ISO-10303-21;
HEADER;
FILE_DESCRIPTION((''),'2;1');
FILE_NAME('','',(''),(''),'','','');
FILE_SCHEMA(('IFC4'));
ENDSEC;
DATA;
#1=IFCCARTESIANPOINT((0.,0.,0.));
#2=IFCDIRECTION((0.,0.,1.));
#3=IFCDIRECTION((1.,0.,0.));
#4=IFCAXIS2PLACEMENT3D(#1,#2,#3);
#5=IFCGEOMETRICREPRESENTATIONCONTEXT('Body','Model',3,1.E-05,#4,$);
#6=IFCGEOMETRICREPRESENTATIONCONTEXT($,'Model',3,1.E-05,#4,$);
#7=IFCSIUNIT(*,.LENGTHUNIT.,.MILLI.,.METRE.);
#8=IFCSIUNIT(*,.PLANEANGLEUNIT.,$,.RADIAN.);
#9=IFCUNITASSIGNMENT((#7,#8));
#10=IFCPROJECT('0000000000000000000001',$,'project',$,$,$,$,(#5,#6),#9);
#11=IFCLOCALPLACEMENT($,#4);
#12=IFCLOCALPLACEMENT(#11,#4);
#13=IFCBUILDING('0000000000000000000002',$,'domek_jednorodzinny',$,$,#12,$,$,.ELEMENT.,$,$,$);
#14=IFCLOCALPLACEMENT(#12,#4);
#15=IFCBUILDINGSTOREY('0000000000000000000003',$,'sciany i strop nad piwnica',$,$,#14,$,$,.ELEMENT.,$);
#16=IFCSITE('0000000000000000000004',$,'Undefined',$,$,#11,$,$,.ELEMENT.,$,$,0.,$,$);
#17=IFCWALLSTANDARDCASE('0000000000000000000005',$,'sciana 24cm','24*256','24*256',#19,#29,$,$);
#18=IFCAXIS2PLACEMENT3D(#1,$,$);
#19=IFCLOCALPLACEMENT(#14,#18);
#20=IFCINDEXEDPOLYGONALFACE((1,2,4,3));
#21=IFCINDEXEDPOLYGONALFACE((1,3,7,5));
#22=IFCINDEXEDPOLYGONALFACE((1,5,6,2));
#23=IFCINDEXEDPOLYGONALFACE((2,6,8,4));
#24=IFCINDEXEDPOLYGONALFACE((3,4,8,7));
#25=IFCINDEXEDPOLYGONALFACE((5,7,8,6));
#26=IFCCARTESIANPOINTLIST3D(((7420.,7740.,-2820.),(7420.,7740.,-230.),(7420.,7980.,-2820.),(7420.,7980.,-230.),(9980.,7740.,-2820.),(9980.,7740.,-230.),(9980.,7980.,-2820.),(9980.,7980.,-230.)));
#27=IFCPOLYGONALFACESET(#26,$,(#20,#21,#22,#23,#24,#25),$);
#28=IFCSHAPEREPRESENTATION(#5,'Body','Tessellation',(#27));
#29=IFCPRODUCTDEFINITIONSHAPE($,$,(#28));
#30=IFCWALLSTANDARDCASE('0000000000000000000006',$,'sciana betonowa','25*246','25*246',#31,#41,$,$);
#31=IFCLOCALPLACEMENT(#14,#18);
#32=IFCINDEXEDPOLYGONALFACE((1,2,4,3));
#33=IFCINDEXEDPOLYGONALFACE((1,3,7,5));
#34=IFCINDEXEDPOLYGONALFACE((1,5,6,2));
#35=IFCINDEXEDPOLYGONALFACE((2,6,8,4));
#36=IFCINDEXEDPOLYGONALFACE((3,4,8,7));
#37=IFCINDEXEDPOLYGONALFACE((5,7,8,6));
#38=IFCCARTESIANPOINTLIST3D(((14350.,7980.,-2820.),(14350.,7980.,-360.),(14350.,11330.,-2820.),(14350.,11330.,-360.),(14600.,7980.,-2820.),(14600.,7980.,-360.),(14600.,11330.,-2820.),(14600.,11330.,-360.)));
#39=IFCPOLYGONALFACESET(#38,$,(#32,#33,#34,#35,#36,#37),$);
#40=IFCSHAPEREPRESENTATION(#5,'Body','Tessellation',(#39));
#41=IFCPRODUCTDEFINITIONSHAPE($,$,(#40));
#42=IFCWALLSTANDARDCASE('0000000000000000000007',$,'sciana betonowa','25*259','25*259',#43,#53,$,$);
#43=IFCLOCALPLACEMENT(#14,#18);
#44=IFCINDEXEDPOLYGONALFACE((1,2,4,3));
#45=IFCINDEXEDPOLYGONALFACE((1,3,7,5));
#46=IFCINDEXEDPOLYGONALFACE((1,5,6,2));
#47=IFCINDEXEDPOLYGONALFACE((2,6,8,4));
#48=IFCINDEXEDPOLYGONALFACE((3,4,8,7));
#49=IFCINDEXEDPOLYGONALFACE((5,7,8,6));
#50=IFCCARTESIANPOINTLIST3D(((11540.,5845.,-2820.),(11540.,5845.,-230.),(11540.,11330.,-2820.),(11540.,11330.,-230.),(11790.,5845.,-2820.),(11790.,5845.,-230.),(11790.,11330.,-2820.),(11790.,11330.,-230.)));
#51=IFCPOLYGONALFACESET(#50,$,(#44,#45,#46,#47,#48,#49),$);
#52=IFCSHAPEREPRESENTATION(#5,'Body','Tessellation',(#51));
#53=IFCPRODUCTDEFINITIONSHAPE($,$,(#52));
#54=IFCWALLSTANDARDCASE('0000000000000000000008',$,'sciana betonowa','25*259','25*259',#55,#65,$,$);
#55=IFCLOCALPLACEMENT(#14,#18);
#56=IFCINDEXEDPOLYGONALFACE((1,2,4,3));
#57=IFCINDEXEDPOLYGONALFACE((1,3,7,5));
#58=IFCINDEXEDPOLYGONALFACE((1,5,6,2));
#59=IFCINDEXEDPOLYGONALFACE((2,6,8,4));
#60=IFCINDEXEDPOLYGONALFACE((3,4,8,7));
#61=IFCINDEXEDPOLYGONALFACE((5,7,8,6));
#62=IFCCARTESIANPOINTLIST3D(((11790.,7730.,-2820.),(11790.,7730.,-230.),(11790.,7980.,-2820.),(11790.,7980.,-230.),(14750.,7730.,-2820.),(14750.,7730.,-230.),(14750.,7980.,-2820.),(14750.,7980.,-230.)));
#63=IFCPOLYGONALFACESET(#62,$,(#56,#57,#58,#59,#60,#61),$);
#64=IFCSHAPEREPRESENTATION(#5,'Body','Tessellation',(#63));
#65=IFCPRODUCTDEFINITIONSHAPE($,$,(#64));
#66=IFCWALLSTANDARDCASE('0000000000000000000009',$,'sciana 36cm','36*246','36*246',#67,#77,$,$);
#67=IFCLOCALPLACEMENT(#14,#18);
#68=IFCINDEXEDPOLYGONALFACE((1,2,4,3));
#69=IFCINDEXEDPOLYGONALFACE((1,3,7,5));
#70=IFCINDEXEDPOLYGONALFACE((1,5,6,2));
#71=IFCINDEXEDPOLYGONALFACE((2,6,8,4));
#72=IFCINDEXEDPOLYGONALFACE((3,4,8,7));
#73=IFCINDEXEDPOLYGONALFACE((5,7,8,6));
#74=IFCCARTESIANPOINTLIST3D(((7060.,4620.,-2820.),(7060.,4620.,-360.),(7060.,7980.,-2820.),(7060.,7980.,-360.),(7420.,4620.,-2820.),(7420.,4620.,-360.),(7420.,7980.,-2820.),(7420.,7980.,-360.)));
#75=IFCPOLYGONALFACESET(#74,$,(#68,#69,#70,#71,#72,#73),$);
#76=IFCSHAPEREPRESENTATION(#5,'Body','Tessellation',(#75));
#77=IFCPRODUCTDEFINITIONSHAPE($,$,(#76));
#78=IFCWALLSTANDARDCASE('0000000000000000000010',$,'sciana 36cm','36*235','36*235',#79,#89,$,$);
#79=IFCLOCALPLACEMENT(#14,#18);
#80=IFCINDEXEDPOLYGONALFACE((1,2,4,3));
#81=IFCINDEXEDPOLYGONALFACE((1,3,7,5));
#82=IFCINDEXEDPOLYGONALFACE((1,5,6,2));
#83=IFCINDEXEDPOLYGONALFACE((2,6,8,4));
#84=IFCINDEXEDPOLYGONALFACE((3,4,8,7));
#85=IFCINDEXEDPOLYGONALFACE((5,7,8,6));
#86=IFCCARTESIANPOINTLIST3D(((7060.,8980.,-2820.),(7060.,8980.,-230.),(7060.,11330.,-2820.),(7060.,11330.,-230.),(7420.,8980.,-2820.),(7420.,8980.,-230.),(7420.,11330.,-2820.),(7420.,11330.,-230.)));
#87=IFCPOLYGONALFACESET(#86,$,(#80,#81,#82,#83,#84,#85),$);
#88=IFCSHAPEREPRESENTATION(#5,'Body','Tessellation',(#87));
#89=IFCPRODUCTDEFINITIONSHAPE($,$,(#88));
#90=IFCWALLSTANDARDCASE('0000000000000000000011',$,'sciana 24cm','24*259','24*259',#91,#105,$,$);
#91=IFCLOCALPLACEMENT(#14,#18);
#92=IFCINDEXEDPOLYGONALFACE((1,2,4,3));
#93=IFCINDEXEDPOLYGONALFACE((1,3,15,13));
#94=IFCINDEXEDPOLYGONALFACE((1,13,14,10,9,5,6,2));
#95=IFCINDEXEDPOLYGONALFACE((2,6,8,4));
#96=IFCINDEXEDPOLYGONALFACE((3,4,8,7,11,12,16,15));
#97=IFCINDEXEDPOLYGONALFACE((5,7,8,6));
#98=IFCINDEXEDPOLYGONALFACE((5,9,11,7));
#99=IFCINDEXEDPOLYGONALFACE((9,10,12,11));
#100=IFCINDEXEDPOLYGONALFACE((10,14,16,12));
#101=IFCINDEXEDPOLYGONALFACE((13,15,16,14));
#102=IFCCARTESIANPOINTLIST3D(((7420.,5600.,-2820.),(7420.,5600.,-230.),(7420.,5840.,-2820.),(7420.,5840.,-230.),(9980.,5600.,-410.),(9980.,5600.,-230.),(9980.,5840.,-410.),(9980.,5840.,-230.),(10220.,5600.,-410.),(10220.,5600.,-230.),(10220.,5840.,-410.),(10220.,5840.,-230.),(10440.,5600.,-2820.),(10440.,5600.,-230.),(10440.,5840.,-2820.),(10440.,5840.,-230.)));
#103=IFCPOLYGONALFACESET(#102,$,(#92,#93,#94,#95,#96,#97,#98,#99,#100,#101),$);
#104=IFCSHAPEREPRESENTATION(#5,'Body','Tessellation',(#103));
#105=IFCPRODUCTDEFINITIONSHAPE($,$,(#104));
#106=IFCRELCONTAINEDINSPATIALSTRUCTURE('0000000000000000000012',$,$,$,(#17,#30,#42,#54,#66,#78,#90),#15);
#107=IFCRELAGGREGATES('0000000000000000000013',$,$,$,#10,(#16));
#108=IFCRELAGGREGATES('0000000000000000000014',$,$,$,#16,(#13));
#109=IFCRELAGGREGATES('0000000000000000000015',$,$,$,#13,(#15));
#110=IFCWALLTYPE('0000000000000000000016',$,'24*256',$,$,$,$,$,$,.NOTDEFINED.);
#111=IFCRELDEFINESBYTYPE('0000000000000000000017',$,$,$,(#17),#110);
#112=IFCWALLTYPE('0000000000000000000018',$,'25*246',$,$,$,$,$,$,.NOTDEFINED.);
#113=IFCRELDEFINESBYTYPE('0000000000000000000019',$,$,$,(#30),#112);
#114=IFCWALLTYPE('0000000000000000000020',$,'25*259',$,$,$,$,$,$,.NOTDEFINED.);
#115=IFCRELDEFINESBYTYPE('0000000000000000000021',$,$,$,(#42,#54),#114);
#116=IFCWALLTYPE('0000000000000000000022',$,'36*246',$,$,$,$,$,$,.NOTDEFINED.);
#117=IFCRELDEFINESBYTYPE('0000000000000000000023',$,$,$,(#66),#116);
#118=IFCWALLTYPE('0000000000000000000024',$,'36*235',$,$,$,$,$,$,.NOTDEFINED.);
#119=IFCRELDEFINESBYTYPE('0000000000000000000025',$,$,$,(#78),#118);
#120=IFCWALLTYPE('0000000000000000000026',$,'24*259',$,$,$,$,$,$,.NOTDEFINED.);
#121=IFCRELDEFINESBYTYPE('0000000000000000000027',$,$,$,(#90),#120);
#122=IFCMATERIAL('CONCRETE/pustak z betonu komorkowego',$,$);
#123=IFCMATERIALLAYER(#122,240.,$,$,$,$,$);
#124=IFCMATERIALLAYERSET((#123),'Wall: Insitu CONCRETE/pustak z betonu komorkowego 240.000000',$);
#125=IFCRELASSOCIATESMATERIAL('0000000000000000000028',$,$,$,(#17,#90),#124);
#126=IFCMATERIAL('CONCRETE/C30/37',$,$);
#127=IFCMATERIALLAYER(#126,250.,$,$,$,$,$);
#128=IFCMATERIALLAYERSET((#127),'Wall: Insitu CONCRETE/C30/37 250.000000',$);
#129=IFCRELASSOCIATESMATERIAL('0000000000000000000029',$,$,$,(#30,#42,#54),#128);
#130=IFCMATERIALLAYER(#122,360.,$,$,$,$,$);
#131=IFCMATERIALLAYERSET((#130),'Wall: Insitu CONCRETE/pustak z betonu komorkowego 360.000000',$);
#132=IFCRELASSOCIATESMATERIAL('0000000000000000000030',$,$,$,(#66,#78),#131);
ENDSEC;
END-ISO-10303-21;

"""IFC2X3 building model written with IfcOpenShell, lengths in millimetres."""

from ifc_helpers import new_model, si_unit, frame, frame_2d, origin_with_axes, place, context, project, spatial, polyline, rectangle, outline, extrude, material, layer, layer_set, layer_usage, type_object, element, save


model = new_model("IFC2X3")

# Units and contexts
model_context_1 = context("Model", 3, precision=1e-05, world=origin_with_axes(), identifier="Body")
model_context_2 = context("Model", 3, precision=1e-05, world=origin_with_axes())
ifc_project = project(units=[si_unit("LENGTHUNIT", "METRE", prefix="MILLI"), si_unit("PLANEANGLEUNIT", "RADIAN")], contexts=[model_context_1, model_context_2])

# Site, building, storey
site_placement = place(None, origin_with_axes())
site = spatial("IfcSite", under=ifc_project, at=site_placement, Name="Undefined", CompositionType="ELEMENT", RefElevation=0.0)
building_placement = place(site_placement, origin_with_axes())
building = spatial("IfcBuilding", under=site, at=building_placement, Name="domek_jednorodzinny", CompositionType="ELEMENT")
storey_placement = place(building_placement, origin_with_axes())
storey = spatial("IfcBuildingStorey", under=building, at=storey_placement, Name="sciany i strop nad piwnica", CompositionType="ELEMENT")

# Shared definitions
ifc_material_1 = material(Name="CONCRETE/C30/37")

# Walls
ifc_material_2 = material(Name="CONCRETE/pustak z betonu komorkowego")
ifc_layer_1 = layer(ifc_material_2, 240.0)
ifc_layer_set_1 = layer_set([ifc_layer_1], Name="Wall: Insitu CONCRETE/pustak z betonu komorkowego 240.000000")
ifc_layer_usage_1 = layer_usage(ifc_layer_set_1, "AXIS2", "POSITIVE", -120.0)
wall_type_1 = type_object("IfcWallType", Name="24*256", PredefinedType="NOTDEFINED")
wall_1_placement = place(storey_placement, frame((7420.0, 7860.0, -2820.0), z_axis=(0.0, 0.0, 1.0), x_axis=(1.0, 0.0, 0.0)))
element("IfcWallStandardCase", 1, at=wall_1_placement, inside=storey, type_object=wall_type_1, material=ifc_layer_usage_1, Name="sciana 24cm", Description="24*256", ObjectType="24*256", context=model_context_1, shape_type="SweptSolid", body=[
    extrude(rectangle(XDim=2560.0, YDim=240.0, at=frame_2d((0.0, 1280.0), x_axis=(0.0, -1.0))), frame((0.0, 0.0, 0.0), z_axis=(0.0, 0.0, 1.0), x_axis=(0.0, -1.0, 0.0)), (0.0, 0.0, 1.0), 2590.0),
])
ifc_layer_2 = layer(ifc_material_1, 250.0)
ifc_layer_set_2 = layer_set([ifc_layer_2], Name="Wall: Insitu CONCRETE/C30/37 250.000000")
ifc_layer_usage_2 = layer_usage(ifc_layer_set_2, "AXIS2", "POSITIVE", -125.0)
wall_type_2 = type_object("IfcWallType", Name="25*246", PredefinedType="NOTDEFINED")
wall_2_placement = place(storey_placement, frame((14475.0, 7980.0, -2820.0), z_axis=(0.0, 0.0, 1.0), x_axis=(0.0, 1.0, 0.0)))
element("IfcWallStandardCase", 2, at=wall_2_placement, inside=storey, type_object=wall_type_2, material=ifc_layer_usage_2, Name="sciana betonowa", Description="25*246", ObjectType="25*246", context=model_context_1, shape_type="SweptSolid", body=[
    extrude(rectangle(XDim=3350.0, YDim=250.0, at=frame_2d((0.0, 1675.0), x_axis=(0.0, -1.0))), frame((0.0, 0.0, 0.0), z_axis=(0.0, 0.0, 1.0), x_axis=(0.0, -1.0, 0.0)), (0.0, 0.0, 1.0), 2460.0),
])
ifc_layer_usage_3 = layer_usage(ifc_layer_set_2, "AXIS2", "POSITIVE", -125.0)
wall_type_3 = type_object("IfcWallType", Name="25*259", PredefinedType="NOTDEFINED")
wall_3_placement = place(storey_placement, frame((11665.0, 5845.0, -2820.0), z_axis=(0.0, 0.0, 1.0), x_axis=(0.0, 1.0, 0.0)))
element("IfcWallStandardCase", 3, at=wall_3_placement, inside=storey, type_object=wall_type_3, material=ifc_layer_usage_3, Name="sciana betonowa", Description="25*259", ObjectType="25*259", context=model_context_1, shape_type="SweptSolid", body=[
    extrude(rectangle(XDim=5485.0, YDim=250.0, at=frame_2d((0.0, 2742.5), x_axis=(0.0, -1.0))), frame((0.0, 0.0, 0.0), z_axis=(0.0, 0.0, 1.0), x_axis=(0.0, -1.0, 0.0)), (0.0, 0.0, 1.0), 2590.0),
])
ifc_layer_usage_4 = layer_usage(ifc_layer_set_2, "AXIS2", "POSITIVE", -125.0)
wall_4_placement = place(storey_placement, frame((11790.0, 7855.0, -2820.0), z_axis=(0.0, 0.0, 1.0), x_axis=(1.0, 0.0, 0.0)))
element("IfcWallStandardCase", 4, at=wall_4_placement, inside=storey, type_object=wall_type_3, material=ifc_layer_usage_4, Name="sciana betonowa", Description="25*259", ObjectType="25*259", context=model_context_1, shape_type="SweptSolid", body=[
    extrude(rectangle(XDim=2960.0, YDim=250.0, at=frame_2d((0.0, 1480.0), x_axis=(0.0, -1.0))), frame((0.0, 0.0, 0.0), z_axis=(0.0, 0.0, 1.0), x_axis=(0.0, -1.0, 0.0)), (0.0, 0.0, 1.0), 2590.0),
])
ifc_layer_3 = layer(ifc_material_2, 360.0)
ifc_layer_set_3 = layer_set([ifc_layer_3], Name="Wall: Insitu CONCRETE/pustak z betonu komorkowego 360.000000")
ifc_layer_usage_5 = layer_usage(ifc_layer_set_3, "AXIS2", "POSITIVE", -180.0)
wall_type_4 = type_object("IfcWallType", Name="36*246", PredefinedType="NOTDEFINED")
wall_5_placement = place(storey_placement, frame((7240.0, 4620.0, -2820.0), z_axis=(0.0, 0.0, 1.0), x_axis=(0.0, 1.0, 0.0)))
element("IfcWallStandardCase", 5, at=wall_5_placement, inside=storey, type_object=wall_type_4, material=ifc_layer_usage_5, Name="sciana 36cm", Description="36*246", ObjectType="36*246", context=model_context_1, shape_type="SweptSolid", body=[
    extrude(rectangle(XDim=3360.0, YDim=360.0, at=frame_2d((0.0, 1680.0), x_axis=(0.0, -1.0))), frame((0.0, 0.0, 0.0), z_axis=(0.0, 0.0, 1.0), x_axis=(0.0, -1.0, 0.0)), (0.0, 0.0, 1.0), 2460.0),
])
ifc_layer_usage_6 = layer_usage(ifc_layer_set_3, "AXIS2", "POSITIVE", -180.0)
wall_type_5 = type_object("IfcWallType", Name="36*235", PredefinedType="NOTDEFINED")
wall_6_placement = place(storey_placement, frame((7240.0, 8980.0, -2820.0), z_axis=(0.0, 0.0, 1.0), x_axis=(0.0, 1.0, 0.0)))
element("IfcWallStandardCase", 6, at=wall_6_placement, inside=storey, type_object=wall_type_5, material=ifc_layer_usage_6, Name="sciana 36cm", Description="36*235", ObjectType="36*235", context=model_context_1, shape_type="SweptSolid", body=[
    extrude(rectangle(XDim=2350.0, YDim=360.0, at=frame_2d((0.0, 1175.0), x_axis=(0.0, -1.0))), frame((0.0, 0.0, 0.0), z_axis=(0.0, 0.0, 1.0), x_axis=(0.0, -1.0, 0.0)), (0.0, 0.0, 1.0), 2590.0),
])

# Wall, opening
ifc_layer_usage_7 = layer_usage(ifc_layer_set_1, "AXIS2", "POSITIVE", -120.0)
wall_type_6 = type_object("IfcWallType", Name="24*259", PredefinedType="NOTDEFINED")
wall_7_placement = place(storey_placement, frame((7420.0, 5720.0, -2820.0), z_axis=(0.0, 0.0, 1.0), x_axis=(1.0, 0.0, 0.0)))
wall_7 = element("IfcWallStandardCase", 7, at=wall_7_placement, inside=storey, type_object=wall_type_6, material=ifc_layer_usage_7, Name="sciana 24cm", Description="24*259", ObjectType="24*259", context=model_context_1, shape_type="SweptSolid", body=[
    extrude(rectangle(XDim=3020.0, YDim=240.0, at=frame_2d((0.0, 1510.0), x_axis=(0.0, -1.0))), frame((0.0, 0.0, 0.0), z_axis=(0.0, 0.0, 1.0), x_axis=(0.0, -1.0, 0.0)), (0.0, 0.0, 1.0), 2590.0),
])
opening_1_placement = place(storey_placement, frame((7420.0, 5720.0, -2820.0), z_axis=(0.0, 0.0, 1.0), x_axis=(1.0, 0.0, 0.0)))
element("IfcOpeningElement", 8, at=opening_1_placement, cuts=wall_7, ObjectType="Recess", context=model_context_1, shape_type="SweptSolid", body=[
    extrude(outline(polyline([(0.0, 0.0), (240.0, 0.0), (240.0, 180.0), (0.0, 180.0), (0.0, 0.0)])), frame((2800.0, -123.0, 2410.0), z_axis=(0.0, 1.0, 0.0), x_axis=(-1.0, 0.0, 0.0)), (0.0, 0.0, 1.0), 246.0),
])

save(model, "model.ifc")
